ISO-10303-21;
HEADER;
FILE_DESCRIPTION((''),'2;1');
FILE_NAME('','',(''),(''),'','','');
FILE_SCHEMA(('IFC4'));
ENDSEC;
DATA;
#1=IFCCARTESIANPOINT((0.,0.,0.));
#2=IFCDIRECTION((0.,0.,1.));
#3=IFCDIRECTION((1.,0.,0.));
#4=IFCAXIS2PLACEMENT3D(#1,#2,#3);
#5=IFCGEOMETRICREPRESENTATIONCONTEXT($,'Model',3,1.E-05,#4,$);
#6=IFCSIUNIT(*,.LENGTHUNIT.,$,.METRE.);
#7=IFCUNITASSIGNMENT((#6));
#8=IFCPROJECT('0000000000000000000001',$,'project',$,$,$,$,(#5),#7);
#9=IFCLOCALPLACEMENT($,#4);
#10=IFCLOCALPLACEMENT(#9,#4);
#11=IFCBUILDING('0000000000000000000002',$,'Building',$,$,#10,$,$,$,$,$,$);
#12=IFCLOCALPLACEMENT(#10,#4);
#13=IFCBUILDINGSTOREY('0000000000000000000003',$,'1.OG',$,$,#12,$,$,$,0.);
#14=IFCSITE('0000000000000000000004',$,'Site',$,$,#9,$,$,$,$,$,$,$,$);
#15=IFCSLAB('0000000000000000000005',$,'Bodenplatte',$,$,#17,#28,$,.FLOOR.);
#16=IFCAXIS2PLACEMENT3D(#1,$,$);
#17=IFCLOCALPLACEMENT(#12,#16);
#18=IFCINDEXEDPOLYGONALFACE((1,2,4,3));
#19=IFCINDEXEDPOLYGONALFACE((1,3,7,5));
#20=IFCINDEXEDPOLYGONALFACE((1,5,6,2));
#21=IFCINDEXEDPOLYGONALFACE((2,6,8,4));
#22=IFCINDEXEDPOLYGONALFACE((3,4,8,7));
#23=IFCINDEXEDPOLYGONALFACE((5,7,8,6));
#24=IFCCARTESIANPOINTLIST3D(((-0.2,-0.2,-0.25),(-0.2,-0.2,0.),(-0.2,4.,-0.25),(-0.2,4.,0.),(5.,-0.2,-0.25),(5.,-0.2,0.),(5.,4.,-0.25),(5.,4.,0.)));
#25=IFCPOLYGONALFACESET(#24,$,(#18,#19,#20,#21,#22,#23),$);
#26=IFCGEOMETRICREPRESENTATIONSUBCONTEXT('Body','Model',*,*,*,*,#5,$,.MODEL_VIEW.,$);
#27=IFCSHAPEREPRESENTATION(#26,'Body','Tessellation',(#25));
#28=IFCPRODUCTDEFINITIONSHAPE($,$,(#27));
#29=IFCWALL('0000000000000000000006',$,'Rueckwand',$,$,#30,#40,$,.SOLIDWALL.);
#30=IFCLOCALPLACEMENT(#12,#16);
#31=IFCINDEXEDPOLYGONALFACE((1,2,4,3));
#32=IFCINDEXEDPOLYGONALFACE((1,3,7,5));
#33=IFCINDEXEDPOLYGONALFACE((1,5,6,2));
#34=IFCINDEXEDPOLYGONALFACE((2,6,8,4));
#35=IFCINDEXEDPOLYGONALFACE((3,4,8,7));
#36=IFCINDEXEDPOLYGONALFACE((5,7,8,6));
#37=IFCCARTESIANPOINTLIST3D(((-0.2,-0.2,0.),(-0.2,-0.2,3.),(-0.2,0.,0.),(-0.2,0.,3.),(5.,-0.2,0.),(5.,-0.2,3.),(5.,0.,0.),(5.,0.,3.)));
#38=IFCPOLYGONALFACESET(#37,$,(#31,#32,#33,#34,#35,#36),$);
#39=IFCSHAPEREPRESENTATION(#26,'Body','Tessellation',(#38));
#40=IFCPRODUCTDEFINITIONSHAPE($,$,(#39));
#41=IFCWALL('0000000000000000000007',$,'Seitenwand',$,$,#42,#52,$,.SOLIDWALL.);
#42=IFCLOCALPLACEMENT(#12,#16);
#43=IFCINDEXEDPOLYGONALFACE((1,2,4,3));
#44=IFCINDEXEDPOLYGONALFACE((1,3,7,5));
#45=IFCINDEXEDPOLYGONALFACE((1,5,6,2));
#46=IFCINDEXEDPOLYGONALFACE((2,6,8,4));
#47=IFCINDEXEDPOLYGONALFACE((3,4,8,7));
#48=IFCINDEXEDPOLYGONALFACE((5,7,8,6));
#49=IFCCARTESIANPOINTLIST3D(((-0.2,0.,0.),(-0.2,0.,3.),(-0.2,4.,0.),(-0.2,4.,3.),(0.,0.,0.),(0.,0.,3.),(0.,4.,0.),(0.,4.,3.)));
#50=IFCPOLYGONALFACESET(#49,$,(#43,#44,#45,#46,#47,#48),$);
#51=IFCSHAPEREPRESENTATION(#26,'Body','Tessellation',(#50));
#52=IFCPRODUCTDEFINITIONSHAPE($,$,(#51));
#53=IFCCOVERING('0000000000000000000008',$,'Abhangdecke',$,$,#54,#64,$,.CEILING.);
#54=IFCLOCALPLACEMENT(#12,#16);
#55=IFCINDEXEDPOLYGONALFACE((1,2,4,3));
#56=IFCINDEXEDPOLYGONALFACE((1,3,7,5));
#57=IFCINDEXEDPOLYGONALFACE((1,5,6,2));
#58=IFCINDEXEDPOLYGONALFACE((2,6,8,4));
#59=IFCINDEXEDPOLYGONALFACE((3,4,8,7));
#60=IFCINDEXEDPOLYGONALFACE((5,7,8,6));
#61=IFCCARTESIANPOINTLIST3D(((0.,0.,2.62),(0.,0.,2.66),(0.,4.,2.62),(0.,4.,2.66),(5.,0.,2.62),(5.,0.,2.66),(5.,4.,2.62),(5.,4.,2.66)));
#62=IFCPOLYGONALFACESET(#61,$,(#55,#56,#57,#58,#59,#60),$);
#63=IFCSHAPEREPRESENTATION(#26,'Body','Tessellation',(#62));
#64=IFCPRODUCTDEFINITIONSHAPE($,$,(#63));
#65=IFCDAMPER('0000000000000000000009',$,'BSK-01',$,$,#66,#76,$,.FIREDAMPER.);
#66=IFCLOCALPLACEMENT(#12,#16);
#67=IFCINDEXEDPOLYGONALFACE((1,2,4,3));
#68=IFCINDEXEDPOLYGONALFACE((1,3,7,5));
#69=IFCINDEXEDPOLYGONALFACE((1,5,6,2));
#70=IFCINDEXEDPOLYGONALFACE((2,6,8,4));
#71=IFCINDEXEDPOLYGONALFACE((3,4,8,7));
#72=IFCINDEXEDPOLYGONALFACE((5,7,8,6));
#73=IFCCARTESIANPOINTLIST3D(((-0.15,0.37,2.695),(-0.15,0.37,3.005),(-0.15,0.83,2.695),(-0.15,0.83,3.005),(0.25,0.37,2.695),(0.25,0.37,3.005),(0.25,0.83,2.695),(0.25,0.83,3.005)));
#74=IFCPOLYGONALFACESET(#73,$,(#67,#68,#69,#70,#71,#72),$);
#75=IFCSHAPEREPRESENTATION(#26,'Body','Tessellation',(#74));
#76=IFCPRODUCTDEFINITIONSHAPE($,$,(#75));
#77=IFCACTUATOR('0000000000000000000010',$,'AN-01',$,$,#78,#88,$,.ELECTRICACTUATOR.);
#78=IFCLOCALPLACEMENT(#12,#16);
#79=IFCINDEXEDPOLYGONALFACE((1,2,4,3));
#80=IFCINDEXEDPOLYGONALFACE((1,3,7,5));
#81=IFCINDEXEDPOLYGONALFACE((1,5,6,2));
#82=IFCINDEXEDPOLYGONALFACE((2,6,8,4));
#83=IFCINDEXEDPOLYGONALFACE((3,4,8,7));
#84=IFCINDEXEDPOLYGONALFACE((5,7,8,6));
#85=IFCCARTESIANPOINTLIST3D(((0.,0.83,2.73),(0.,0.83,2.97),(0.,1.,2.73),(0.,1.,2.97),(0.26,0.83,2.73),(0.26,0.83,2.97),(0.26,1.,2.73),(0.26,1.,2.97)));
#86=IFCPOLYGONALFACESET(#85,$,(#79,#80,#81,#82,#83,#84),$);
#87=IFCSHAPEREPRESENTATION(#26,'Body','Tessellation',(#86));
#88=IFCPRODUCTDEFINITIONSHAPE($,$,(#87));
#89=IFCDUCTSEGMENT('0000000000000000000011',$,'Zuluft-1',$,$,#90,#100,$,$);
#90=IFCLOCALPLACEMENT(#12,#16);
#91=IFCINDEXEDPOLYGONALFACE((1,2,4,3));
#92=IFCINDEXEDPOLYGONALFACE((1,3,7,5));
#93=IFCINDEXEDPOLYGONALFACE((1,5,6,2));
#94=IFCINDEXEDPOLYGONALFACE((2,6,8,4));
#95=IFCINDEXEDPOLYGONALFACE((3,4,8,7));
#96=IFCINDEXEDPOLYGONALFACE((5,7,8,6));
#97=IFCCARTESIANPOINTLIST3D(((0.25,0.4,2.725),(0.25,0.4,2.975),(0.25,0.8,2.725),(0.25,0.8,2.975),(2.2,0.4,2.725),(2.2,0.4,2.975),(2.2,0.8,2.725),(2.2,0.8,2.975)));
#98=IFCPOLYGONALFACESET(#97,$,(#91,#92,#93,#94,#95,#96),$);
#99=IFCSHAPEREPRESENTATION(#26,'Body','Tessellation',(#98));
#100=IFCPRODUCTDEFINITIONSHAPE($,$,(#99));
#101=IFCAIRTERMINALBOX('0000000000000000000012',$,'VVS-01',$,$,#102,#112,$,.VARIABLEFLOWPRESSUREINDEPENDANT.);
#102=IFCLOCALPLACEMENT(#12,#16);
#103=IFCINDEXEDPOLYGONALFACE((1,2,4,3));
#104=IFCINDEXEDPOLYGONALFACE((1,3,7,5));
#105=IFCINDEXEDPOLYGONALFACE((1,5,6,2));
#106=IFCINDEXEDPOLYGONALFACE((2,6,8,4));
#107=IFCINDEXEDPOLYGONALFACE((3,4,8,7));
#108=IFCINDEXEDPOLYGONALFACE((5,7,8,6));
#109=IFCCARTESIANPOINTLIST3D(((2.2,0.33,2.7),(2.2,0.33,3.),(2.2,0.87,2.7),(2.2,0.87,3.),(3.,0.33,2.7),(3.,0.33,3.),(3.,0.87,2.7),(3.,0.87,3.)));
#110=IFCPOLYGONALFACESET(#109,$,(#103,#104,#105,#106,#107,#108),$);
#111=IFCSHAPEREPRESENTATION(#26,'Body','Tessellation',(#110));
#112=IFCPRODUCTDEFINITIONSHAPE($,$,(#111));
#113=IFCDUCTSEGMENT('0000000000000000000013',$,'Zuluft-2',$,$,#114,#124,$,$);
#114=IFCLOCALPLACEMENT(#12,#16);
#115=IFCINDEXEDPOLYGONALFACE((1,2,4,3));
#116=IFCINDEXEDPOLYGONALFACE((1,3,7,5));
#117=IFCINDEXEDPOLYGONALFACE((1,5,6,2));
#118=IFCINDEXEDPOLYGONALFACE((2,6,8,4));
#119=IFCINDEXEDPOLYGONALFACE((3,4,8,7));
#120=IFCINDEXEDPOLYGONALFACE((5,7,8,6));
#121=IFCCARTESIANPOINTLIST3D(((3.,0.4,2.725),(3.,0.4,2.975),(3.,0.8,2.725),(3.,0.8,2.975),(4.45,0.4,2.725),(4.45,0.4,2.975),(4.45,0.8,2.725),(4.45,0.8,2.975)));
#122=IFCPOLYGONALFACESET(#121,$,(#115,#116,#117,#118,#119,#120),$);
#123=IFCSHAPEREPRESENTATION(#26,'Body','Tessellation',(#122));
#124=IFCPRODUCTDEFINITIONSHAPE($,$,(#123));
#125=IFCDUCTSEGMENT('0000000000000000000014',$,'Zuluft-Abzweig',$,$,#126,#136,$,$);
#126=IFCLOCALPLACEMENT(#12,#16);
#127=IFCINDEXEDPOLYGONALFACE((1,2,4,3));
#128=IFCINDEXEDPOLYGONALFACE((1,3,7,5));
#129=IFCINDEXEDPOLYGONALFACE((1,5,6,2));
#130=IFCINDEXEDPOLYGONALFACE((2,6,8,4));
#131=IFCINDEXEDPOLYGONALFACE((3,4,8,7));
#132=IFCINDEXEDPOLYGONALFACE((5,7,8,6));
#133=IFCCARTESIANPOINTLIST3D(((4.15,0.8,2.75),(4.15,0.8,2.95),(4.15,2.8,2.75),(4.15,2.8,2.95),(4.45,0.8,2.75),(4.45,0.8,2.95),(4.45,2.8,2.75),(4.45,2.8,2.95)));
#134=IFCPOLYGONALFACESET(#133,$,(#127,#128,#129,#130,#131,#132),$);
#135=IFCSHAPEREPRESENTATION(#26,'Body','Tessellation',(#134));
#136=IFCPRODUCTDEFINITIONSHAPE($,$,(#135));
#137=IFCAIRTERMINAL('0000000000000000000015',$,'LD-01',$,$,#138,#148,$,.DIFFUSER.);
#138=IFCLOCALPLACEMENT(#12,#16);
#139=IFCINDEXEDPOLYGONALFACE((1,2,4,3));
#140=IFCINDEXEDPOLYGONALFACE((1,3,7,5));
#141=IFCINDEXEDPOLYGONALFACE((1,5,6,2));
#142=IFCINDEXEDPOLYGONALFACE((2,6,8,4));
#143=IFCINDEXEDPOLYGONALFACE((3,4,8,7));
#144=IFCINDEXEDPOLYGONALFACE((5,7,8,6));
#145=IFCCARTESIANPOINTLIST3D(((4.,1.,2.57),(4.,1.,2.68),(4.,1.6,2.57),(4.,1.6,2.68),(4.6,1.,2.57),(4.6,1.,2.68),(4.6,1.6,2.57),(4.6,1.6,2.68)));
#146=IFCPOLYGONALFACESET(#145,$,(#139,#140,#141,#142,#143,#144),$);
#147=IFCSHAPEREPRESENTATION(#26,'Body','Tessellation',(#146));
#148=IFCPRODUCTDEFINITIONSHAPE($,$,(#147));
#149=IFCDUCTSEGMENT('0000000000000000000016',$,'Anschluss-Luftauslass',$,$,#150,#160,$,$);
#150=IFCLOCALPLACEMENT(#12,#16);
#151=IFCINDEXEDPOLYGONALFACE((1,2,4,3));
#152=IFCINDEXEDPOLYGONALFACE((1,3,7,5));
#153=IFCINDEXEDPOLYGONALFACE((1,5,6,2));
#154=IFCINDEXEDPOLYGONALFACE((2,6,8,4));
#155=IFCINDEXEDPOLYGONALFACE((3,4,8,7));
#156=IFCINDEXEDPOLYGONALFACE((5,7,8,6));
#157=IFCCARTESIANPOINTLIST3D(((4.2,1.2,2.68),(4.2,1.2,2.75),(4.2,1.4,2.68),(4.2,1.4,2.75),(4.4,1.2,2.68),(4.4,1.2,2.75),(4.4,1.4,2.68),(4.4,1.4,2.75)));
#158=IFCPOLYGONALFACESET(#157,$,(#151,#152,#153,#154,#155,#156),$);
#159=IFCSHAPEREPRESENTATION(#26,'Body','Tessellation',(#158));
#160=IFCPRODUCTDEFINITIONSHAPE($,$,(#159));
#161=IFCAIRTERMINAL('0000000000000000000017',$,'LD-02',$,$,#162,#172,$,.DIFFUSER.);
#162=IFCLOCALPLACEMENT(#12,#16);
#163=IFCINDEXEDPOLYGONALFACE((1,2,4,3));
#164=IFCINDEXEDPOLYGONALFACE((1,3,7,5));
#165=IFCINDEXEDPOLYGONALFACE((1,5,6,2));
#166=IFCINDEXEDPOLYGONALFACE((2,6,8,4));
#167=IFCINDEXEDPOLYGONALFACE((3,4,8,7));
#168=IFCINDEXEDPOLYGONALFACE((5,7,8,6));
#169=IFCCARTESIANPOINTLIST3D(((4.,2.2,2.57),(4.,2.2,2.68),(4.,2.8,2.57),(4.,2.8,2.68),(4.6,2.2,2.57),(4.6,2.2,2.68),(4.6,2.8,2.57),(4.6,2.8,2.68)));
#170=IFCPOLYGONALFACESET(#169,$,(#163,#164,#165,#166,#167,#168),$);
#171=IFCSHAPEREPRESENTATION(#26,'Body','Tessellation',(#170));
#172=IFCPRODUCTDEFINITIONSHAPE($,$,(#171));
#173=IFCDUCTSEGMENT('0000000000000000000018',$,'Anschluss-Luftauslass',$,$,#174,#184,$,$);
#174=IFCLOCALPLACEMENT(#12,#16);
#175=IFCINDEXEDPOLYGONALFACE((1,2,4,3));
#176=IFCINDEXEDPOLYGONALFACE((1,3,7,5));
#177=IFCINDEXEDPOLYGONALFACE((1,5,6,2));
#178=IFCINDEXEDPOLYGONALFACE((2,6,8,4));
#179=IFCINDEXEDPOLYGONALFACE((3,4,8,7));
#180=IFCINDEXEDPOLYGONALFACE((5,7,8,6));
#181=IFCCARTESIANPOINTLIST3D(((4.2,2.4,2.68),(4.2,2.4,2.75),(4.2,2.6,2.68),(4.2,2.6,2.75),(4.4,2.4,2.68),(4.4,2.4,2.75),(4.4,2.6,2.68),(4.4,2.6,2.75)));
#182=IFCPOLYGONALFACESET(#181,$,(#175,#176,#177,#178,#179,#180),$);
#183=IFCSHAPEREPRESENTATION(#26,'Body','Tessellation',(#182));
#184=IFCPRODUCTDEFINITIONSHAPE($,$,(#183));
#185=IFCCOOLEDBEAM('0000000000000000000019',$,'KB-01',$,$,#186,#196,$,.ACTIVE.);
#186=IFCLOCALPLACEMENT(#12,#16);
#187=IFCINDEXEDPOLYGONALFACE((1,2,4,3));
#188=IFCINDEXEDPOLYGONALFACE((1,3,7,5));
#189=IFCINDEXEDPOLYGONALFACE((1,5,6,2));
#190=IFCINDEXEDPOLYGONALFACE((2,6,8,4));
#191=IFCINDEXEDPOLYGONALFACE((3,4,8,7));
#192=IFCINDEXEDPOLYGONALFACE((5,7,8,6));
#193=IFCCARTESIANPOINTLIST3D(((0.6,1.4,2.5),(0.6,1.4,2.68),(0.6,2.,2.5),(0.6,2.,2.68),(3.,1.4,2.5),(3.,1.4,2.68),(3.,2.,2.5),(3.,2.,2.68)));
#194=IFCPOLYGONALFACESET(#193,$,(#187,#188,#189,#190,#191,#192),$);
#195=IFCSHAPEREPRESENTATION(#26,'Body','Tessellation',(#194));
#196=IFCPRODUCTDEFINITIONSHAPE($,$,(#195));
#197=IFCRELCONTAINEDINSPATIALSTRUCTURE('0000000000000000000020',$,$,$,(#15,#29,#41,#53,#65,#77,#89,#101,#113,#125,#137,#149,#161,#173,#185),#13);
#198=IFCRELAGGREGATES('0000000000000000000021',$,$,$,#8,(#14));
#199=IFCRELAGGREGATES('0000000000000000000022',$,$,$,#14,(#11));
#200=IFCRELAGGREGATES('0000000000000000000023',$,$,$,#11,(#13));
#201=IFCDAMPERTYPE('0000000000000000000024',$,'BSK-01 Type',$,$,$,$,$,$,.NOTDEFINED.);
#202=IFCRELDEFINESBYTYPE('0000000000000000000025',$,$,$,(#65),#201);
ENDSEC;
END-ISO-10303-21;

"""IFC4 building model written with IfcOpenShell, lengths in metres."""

from ifc_helpers import new_model, si_unit, frame, origin_with_axes, place, context, subcontext, project, spatial, polyline, outline, extrude, type_object, element, save


model = new_model("IFC4")

# Units and contexts
model_context = context("Model", 3, precision=1e-05, world=origin_with_axes())
body_context = subcontext(model_context, "Body", "Model", "MODEL_VIEW")
ifc_project = project(units=[si_unit("LENGTHUNIT", "METRE")], contexts=[model_context])

# Site, building, storey
site_placement = place(None, origin_with_axes())
site = spatial("IfcSite", under=ifc_project, at=site_placement, Name="Site")
building_placement = place(site_placement, origin_with_axes())
building = spatial("IfcBuilding", under=site, at=building_placement, Name="Building")
storey_placement = place(building_placement, origin_with_axes())
storey = spatial("IfcBuildingStorey", under=building, at=storey_placement, Name="1.OG", Elevation=0.0)

# Slab
slab_placement = place(storey_placement, frame((0.0, 0.0, -0.25), z_axis=(0.0, 0.0, 1.0), x_axis=(1.0, 0.0, 0.0)))
element("IfcSlab", 1, at=slab_placement, inside=storey, Name="Bodenplatte", PredefinedType="FLOOR", context=body_context, shape_type="SweptSolid", body=[
    extrude(outline(polyline([(-0.2, -0.2, 0.0), (5.0, -0.2, 0.0), (5.0, 4.0, 0.0), (-0.2, 4.0, 0.0), (-0.2, -0.2, 0.0)])), origin_with_axes(), (0.0, 0.0, 1.0), 0.25),
])

# Walls
wall_1_placement = place(storey_placement, frame((-0.2, -0.2, 0.0), z_axis=(0.0, 0.0, 1.0), x_axis=(1.0, 0.0, 0.0)))
element("IfcWall", 2, at=wall_1_placement, inside=storey, Name="Rueckwand", PredefinedType="SOLIDWALL", context=body_context, shape_type="SweptSolid", body=[
    extrude(outline(polyline([(0.0, 0.0, 0.0), (5.2, 0.0, 0.0), (5.2, 0.2, 0.0), (0.0, 0.2, 0.0), (0.0, 0.0, 0.0)])), origin_with_axes(), (0.0, 0.0, 1.0), 3.0),
])
wall_2_placement = place(storey_placement, frame((0.0, 0.0, 0.0), z_axis=(0.0, 0.0, 1.0), x_axis=(0.0, 1.0, 0.0)))
element("IfcWall", 3, at=wall_2_placement, inside=storey, Name="Seitenwand", PredefinedType="SOLIDWALL", context=body_context, shape_type="SweptSolid", body=[
    extrude(outline(polyline([(0.0, 0.0, 0.0), (4.0, 0.0, 0.0), (4.0, 0.2, 0.0), (0.0, 0.2, 0.0), (0.0, 0.0, 0.0)])), origin_with_axes(), (0.0, 0.0, 1.0), 3.0),
])

# Covering
covering_placement = place(storey_placement, frame((0.0, 0.0, 2.62), z_axis=(0.0, 0.0, 1.0), x_axis=(1.0, 0.0, 0.0)))
element("IfcCovering", 4, at=covering_placement, inside=storey, Name="Abhangdecke", PredefinedType="CEILING", context=body_context, shape_type="SweptSolid", body=[
    extrude(outline(polyline([(0.0, 0.0, 0.0), (5.0, 0.0, 0.0), (5.0, 4.0, 0.0), (0.0, 4.0, 0.0), (0.0, 0.0, 0.0)])), origin_with_axes(), (0.0, 0.0, 1.0), 0.04),
])

# Damper
damper_type = type_object("IfcDamperType", Name="BSK-01 Type", PredefinedType="NOTDEFINED")
damper_placement = place(storey_placement, origin_with_axes())
element("IfcDamper", 5, at=damper_placement, inside=storey, type_object=damper_type, Name="BSK-01", PredefinedType="FIREDAMPER", context=body_context, shape_type="SweptSolid", body=[
    extrude(outline(polyline([(-0.15, 0.37, 0.0), (0.25, 0.37, 0.0), (0.25, 0.83, 0.0), (-0.15, 0.83, 0.0), (-0.15, 0.37, 0.0)])), frame((0.0, 0.0, 2.695), z_axis=(0.0, 0.0, 1.0), x_axis=(1.0, 0.0, 0.0)), (0.0, 0.0, 1.0), 0.31),
])

# Actuator
actuator_placement = place(storey_placement, origin_with_axes())
element("IfcActuator", 6, at=actuator_placement, inside=storey, Name="AN-01", PredefinedType="ELECTRICACTUATOR", context=body_context, shape_type="SweptSolid", body=[
    extrude(outline(polyline([(0.0, 0.83, 0.0), (0.26, 0.83, 0.0), (0.26, 1.0, 0.0), (0.0, 1.0, 0.0), (0.0, 0.83, 0.0)])), frame((0.0, 0.0, 2.73), z_axis=(0.0, 0.0, 1.0), x_axis=(1.0, 0.0, 0.0)), (0.0, 0.0, 1.0), 0.24),
])

# Duct segment
duct_segment_1_placement = place(storey_placement, origin_with_axes())
element("IfcDuctSegment", 7, at=duct_segment_1_placement, inside=storey, Name="Zuluft-1", context=body_context, shape_type="SweptSolid", body=[
    extrude(outline(polyline([(-0.2, -0.125, 0.0), (0.2, -0.125, 0.0), (0.2, 0.125, 0.0), (-0.2, 0.125, 0.0), (-0.2, -0.125, 0.0)])), frame((0.25, 0.6, 2.85), z_axis=(1.0, 0.0, 0.0), x_axis=(0.0, 1.0, 0.0)), (0.0, 0.0, 1.0), 1.95),
])

# Air terminal box
air_terminal_box_placement = place(storey_placement, origin_with_axes())
element("IfcAirTerminalBox", 8, at=air_terminal_box_placement, inside=storey, Name="VVS-01", PredefinedType="VARIABLEFLOWPRESSUREINDEPENDANT", context=body_context, shape_type="SweptSolid", body=[
    extrude(outline(polyline([(2.2, 0.33, 0.0), (3.0, 0.33, 0.0), (3.0, 0.87, 0.0), (2.2, 0.87, 0.0), (2.2, 0.33, 0.0)])), frame((0.0, 0.0, 2.7), z_axis=(0.0, 0.0, 1.0), x_axis=(1.0, 0.0, 0.0)), (0.0, 0.0, 1.0), 0.3),
])

# Duct segments
duct_segment_2_placement = place(storey_placement, origin_with_axes())
element("IfcDuctSegment", 9, at=duct_segment_2_placement, inside=storey, Name="Zuluft-2", context=body_context, shape_type="SweptSolid", body=[
    extrude(outline(polyline([(-0.2, -0.125, 0.0), (0.2, -0.125, 0.0), (0.2, 0.125, 0.0), (-0.2, 0.125, 0.0), (-0.2, -0.125, 0.0)])), frame((3.0, 0.6, 2.85), z_axis=(1.0, 0.0, 0.0), x_axis=(0.0, 1.0, 0.0)), (0.0, 0.0, 1.0), 1.45),
])
duct_segment_3_placement = place(storey_placement, origin_with_axes())
element("IfcDuctSegment", 10, at=duct_segment_3_placement, inside=storey, Name="Zuluft-Abzweig", context=body_context, shape_type="SweptSolid", body=[
    extrude(outline(polyline([(-0.15, -0.1, 0.0), (0.15, -0.1, 0.0), (0.15, 0.1, 0.0), (-0.15, 0.1, 0.0), (-0.15, -0.1, 0.0)])), frame((4.3, 0.8, 2.85), z_axis=(0.0, 1.0, 0.0), x_axis=(-1.0, 0.0, 0.0)), (0.0, 0.0, 1.0), 2.0),
])

# Air terminal
air_terminal_1_placement = place(storey_placement, origin_with_axes())
element("IfcAirTerminal", 11, at=air_terminal_1_placement, inside=storey, Name="LD-01", PredefinedType="DIFFUSER", context=body_context, shape_type="SweptSolid", body=[
    extrude(outline(polyline([(4.0, 1.0, 0.0), (4.6, 1.0, 0.0), (4.6, 1.6, 0.0), (4.0, 1.6, 0.0), (4.0, 1.0, 0.0)])), frame((0.0, 0.0, 2.57), z_axis=(0.0, 0.0, 1.0), x_axis=(1.0, 0.0, 0.0)), (0.0, 0.0, 1.0), 0.11),
])

# Duct segment
duct_segment_4_placement = place(storey_placement, origin_with_axes())
element("IfcDuctSegment", 12, at=duct_segment_4_placement, inside=storey, Name="Anschluss-Luftauslass", context=body_context, shape_type="SweptSolid", body=[
    extrude(outline(polyline([(-0.1, -0.1, 0.0), (0.1, -0.1, 0.0), (0.1, 0.1, 0.0), (-0.1, 0.1, 0.0), (-0.1, -0.1, 0.0)])), frame((4.3, 1.3, 2.68), z_axis=(0.0, 0.0, 1.0), x_axis=(1.0, 0.0, 0.0)), (0.0, 0.0, 1.0), 0.07),
])

# Air terminal
air_terminal_2_placement = place(storey_placement, origin_with_axes())
element("IfcAirTerminal", 13, at=air_terminal_2_placement, inside=storey, Name="LD-02", PredefinedType="DIFFUSER", context=body_context, shape_type="SweptSolid", body=[
    extrude(outline(polyline([(4.0, 2.2, 0.0), (4.6, 2.2, 0.0), (4.6, 2.8, 0.0), (4.0, 2.8, 0.0), (4.0, 2.2, 0.0)])), frame((0.0, 0.0, 2.57), z_axis=(0.0, 0.0, 1.0), x_axis=(1.0, 0.0, 0.0)), (0.0, 0.0, 1.0), 0.11),
])

# Duct segment
duct_segment_5_placement = place(storey_placement, origin_with_axes())
element("IfcDuctSegment", 14, at=duct_segment_5_placement, inside=storey, Name="Anschluss-Luftauslass", context=body_context, shape_type="SweptSolid", body=[
    extrude(outline(polyline([(-0.1, -0.1, 0.0), (0.1, -0.1, 0.0), (0.1, 0.1, 0.0), (-0.1, 0.1, 0.0), (-0.1, -0.1, 0.0)])), frame((4.3, 2.5, 2.68), z_axis=(0.0, 0.0, 1.0), x_axis=(1.0, 0.0, 0.0)), (0.0, 0.0, 1.0), 0.07),
])

# Cooled beam
cooled_beam_placement = place(storey_placement, origin_with_axes())
element("IfcCooledBeam", 15, at=cooled_beam_placement, inside=storey, Name="KB-01", PredefinedType="ACTIVE", context=body_context, shape_type="SweptSolid", body=[
    extrude(outline(polyline([(0.6, 1.4, 0.0), (3.0, 1.4, 0.0), (3.0, 2.0, 0.0), (0.6, 2.0, 0.0), (0.6, 1.4, 0.0)])), frame((0.0, 0.0, 2.5), z_axis=(0.0, 0.0, 1.0), x_axis=(1.0, 0.0, 0.0)), (0.0, 0.0, 1.0), 0.18),
])

save(model, "model.ifc")
